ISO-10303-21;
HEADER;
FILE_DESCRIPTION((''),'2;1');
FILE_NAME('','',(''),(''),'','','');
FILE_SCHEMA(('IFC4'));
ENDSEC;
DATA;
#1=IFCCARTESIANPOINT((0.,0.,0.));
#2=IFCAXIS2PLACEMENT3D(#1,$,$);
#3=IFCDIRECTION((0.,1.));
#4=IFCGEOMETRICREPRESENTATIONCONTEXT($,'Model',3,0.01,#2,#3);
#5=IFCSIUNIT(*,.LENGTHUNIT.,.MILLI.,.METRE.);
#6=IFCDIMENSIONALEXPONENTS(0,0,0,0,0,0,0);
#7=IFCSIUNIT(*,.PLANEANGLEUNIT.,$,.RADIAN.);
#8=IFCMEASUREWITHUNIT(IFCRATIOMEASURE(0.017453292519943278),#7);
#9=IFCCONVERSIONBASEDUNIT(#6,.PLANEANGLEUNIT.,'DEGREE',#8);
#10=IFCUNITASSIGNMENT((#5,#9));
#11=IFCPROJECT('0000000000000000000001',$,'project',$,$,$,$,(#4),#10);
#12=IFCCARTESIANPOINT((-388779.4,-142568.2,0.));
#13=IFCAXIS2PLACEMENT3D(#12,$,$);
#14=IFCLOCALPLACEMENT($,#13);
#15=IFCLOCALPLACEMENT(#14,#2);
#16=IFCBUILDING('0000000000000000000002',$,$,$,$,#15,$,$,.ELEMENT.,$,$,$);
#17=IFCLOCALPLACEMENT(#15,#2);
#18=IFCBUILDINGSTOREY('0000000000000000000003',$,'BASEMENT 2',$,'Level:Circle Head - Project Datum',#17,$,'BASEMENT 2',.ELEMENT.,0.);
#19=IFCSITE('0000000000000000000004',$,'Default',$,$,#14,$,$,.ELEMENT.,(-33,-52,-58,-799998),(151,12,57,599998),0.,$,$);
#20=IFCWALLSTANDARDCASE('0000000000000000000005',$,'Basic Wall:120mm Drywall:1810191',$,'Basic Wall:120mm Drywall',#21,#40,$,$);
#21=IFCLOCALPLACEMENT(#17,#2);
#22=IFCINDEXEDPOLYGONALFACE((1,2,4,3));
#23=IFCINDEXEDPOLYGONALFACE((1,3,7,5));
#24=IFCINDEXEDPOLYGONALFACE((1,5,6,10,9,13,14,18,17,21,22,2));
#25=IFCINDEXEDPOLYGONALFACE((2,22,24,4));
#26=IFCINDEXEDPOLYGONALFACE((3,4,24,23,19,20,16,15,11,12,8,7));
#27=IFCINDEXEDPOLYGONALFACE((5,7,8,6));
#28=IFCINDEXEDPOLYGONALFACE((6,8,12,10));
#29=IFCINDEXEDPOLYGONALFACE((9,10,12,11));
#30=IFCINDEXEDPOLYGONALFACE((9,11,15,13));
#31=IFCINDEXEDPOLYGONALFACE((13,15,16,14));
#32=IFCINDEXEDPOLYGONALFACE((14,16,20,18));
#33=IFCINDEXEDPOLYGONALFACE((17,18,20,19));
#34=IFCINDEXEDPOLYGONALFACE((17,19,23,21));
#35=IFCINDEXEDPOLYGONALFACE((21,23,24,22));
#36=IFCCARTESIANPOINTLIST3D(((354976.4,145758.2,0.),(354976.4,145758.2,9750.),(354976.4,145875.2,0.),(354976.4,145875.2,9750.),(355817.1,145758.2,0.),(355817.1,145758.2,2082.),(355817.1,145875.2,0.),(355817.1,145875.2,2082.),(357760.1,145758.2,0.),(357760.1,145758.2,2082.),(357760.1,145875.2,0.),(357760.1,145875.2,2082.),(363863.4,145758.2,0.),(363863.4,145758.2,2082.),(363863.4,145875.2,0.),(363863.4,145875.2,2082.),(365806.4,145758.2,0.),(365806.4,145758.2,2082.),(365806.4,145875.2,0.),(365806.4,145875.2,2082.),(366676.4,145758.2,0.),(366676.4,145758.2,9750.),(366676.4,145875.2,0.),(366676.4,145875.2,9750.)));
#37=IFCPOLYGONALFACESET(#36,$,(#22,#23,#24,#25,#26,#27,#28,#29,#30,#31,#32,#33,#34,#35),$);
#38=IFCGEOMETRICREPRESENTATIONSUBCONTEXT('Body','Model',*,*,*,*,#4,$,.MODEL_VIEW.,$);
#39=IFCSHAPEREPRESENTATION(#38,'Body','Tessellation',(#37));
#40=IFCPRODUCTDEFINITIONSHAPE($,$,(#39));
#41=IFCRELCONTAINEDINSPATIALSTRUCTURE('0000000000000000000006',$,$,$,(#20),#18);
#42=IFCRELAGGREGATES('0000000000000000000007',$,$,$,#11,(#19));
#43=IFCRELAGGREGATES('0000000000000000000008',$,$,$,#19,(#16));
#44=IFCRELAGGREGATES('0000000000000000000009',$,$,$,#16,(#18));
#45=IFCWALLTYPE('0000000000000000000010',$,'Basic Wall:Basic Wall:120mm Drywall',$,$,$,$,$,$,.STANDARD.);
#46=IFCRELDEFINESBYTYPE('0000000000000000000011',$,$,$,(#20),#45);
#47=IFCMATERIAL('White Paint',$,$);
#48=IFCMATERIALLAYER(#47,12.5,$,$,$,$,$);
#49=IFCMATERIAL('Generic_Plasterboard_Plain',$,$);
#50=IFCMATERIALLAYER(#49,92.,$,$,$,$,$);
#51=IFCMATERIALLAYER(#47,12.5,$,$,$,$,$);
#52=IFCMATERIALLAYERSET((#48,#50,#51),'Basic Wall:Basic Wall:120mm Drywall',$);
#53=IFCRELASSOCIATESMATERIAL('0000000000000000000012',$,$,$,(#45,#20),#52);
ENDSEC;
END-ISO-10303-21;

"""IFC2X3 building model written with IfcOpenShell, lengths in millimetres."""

from ifc_helpers import new_model, entity, si_unit, converted_unit, direction, frame, frame_2d, origin, place, context, subcontext, project, spatial, rectangle, extrude, material, layer, layer_set, layer_usage, type_object, element, save


model = new_model("IFC2X3")

# Units and contexts
model_context = context("Model", 3, precision=0.01, world=origin(), true_north=direction((0.0, 1.0)))
body_context = subcontext(model_context, "Body", "Model", "MODEL_VIEW")
ifc_project = project(units=[si_unit("LENGTHUNIT", "METRE", prefix="MILLI"), converted_unit("PLANEANGLEUNIT", "DEGREE", entity("IfcRatioMeasure", 0.017453292519943278), si_unit("PLANEANGLEUNIT", "RADIAN"), dimensions=[0, 0, 0, 0, 0, 0, 0])], contexts=[model_context])

# Site, building, storey
site_placement = place(None, frame((-388779.4, -142568.2, 0.0)))
site = spatial("IfcSite", under=ifc_project, at=site_placement, Name="Default", CompositionType="ELEMENT", RefLatitude=(-33, -52, -58, -799998), RefLongitude=(151, 12, 57, 599998), RefElevation=0.0)
building_placement = place(site_placement, origin())
building = spatial("IfcBuilding", under=site, at=building_placement, CompositionType="ELEMENT")
storey_placement = place(building_placement, origin())
storey = spatial("IfcBuildingStorey", under=building, at=storey_placement, Name="BASEMENT 2", ObjectType="Level:Circle Head - Project Datum", LongName="BASEMENT 2", CompositionType="ELEMENT", Elevation=0.0)

# Wall, openings
ifc_material_1 = material(Name="White Paint")
ifc_layer_1 = layer(ifc_material_1, 12.5)
ifc_material_2 = material(Name="Generic_Plasterboard_Plain")
ifc_layer_2 = layer(ifc_material_2, 92.0)
ifc_layer_3 = layer(ifc_material_1, 12.5)
ifc_layer_set_1 = layer_set([ifc_layer_1, ifc_layer_2, ifc_layer_3], Name="Basic Wall:Basic Wall:120mm Drywall")
ifc_layer_usage_1 = layer_usage(ifc_layer_set_1, "AXIS2", "NEGATIVE", 58.5)
wall_type_1 = type_object("IfcWallType", Name="Basic Wall:Basic Wall:120mm Drywall", PredefinedType="STANDARD", material=ifc_layer_set_1)
wall_1_placement = place(storey_placement, frame((366676.4, 145816.7, 0.0), z_axis=(0.0, 0.0, 1.0), x_axis=(-1.0, 0.0, 0.0)))
wall_1 = element("IfcWallStandardCase", 1, at=wall_1_placement, inside=storey, type_object=wall_type_1, material=ifc_layer_usage_1, Name="Basic Wall:120mm Drywall:1810191", ObjectType="Basic Wall:120mm Drywall", context=body_context, shape_type="SweptSolid", body=[
    extrude(rectangle(XDim=11700.0, YDim=117.0, at=frame_2d((5850.0, 0.0), x_axis=(1.0, 0.0))), origin(), (0.0, 0.0, 1.0), 9750.0),
])
opening_1_placement = place(wall_1_placement, frame((366676.4, 145816.7, 0.0), z_axis=(0.0, 0.0, 1.0), x_axis=(-1.0, 0.0, 0.0)))
element("IfcOpeningElement", 2, at=opening_1_placement, cuts=wall_1, ObjectType="Opening", context=body_context, shape_type="SweptSolid", body=[
    extrude(rectangle(XDim=2082.0, YDim=1943.0, at=frame_2d((0.0, 0.0), x_axis=(1.0, 0.0))), frame((364834.9, 145876.3, 1041.0), z_axis=(0.0, -1.0, 0.0), x_axis=(0.0, 0.0, -1.0)), (0.0, 0.0, 1.0), 119.3),
])
opening_2_placement = place(wall_1_placement, frame((366676.4, 145816.7, 0.0), z_axis=(0.0, 0.0, 1.0), x_axis=(-1.0, 0.0, 0.0)))
element("IfcOpeningElement", 3, at=opening_2_placement, cuts=wall_1, ObjectType="Opening", context=body_context, shape_type="SweptSolid", body=[
    extrude(rectangle(XDim=2082.0, YDim=1943.0, at=frame_2d((0.0, 0.0), x_axis=(1.0, 0.0))), frame((356788.6, 145876.3, 1041.0), z_axis=(0.0, -1.0, 0.0), x_axis=(0.0, 0.0, -1.0)), (0.0, 0.0, 1.0), 119.3),
])

save(model, "model.ifc")
